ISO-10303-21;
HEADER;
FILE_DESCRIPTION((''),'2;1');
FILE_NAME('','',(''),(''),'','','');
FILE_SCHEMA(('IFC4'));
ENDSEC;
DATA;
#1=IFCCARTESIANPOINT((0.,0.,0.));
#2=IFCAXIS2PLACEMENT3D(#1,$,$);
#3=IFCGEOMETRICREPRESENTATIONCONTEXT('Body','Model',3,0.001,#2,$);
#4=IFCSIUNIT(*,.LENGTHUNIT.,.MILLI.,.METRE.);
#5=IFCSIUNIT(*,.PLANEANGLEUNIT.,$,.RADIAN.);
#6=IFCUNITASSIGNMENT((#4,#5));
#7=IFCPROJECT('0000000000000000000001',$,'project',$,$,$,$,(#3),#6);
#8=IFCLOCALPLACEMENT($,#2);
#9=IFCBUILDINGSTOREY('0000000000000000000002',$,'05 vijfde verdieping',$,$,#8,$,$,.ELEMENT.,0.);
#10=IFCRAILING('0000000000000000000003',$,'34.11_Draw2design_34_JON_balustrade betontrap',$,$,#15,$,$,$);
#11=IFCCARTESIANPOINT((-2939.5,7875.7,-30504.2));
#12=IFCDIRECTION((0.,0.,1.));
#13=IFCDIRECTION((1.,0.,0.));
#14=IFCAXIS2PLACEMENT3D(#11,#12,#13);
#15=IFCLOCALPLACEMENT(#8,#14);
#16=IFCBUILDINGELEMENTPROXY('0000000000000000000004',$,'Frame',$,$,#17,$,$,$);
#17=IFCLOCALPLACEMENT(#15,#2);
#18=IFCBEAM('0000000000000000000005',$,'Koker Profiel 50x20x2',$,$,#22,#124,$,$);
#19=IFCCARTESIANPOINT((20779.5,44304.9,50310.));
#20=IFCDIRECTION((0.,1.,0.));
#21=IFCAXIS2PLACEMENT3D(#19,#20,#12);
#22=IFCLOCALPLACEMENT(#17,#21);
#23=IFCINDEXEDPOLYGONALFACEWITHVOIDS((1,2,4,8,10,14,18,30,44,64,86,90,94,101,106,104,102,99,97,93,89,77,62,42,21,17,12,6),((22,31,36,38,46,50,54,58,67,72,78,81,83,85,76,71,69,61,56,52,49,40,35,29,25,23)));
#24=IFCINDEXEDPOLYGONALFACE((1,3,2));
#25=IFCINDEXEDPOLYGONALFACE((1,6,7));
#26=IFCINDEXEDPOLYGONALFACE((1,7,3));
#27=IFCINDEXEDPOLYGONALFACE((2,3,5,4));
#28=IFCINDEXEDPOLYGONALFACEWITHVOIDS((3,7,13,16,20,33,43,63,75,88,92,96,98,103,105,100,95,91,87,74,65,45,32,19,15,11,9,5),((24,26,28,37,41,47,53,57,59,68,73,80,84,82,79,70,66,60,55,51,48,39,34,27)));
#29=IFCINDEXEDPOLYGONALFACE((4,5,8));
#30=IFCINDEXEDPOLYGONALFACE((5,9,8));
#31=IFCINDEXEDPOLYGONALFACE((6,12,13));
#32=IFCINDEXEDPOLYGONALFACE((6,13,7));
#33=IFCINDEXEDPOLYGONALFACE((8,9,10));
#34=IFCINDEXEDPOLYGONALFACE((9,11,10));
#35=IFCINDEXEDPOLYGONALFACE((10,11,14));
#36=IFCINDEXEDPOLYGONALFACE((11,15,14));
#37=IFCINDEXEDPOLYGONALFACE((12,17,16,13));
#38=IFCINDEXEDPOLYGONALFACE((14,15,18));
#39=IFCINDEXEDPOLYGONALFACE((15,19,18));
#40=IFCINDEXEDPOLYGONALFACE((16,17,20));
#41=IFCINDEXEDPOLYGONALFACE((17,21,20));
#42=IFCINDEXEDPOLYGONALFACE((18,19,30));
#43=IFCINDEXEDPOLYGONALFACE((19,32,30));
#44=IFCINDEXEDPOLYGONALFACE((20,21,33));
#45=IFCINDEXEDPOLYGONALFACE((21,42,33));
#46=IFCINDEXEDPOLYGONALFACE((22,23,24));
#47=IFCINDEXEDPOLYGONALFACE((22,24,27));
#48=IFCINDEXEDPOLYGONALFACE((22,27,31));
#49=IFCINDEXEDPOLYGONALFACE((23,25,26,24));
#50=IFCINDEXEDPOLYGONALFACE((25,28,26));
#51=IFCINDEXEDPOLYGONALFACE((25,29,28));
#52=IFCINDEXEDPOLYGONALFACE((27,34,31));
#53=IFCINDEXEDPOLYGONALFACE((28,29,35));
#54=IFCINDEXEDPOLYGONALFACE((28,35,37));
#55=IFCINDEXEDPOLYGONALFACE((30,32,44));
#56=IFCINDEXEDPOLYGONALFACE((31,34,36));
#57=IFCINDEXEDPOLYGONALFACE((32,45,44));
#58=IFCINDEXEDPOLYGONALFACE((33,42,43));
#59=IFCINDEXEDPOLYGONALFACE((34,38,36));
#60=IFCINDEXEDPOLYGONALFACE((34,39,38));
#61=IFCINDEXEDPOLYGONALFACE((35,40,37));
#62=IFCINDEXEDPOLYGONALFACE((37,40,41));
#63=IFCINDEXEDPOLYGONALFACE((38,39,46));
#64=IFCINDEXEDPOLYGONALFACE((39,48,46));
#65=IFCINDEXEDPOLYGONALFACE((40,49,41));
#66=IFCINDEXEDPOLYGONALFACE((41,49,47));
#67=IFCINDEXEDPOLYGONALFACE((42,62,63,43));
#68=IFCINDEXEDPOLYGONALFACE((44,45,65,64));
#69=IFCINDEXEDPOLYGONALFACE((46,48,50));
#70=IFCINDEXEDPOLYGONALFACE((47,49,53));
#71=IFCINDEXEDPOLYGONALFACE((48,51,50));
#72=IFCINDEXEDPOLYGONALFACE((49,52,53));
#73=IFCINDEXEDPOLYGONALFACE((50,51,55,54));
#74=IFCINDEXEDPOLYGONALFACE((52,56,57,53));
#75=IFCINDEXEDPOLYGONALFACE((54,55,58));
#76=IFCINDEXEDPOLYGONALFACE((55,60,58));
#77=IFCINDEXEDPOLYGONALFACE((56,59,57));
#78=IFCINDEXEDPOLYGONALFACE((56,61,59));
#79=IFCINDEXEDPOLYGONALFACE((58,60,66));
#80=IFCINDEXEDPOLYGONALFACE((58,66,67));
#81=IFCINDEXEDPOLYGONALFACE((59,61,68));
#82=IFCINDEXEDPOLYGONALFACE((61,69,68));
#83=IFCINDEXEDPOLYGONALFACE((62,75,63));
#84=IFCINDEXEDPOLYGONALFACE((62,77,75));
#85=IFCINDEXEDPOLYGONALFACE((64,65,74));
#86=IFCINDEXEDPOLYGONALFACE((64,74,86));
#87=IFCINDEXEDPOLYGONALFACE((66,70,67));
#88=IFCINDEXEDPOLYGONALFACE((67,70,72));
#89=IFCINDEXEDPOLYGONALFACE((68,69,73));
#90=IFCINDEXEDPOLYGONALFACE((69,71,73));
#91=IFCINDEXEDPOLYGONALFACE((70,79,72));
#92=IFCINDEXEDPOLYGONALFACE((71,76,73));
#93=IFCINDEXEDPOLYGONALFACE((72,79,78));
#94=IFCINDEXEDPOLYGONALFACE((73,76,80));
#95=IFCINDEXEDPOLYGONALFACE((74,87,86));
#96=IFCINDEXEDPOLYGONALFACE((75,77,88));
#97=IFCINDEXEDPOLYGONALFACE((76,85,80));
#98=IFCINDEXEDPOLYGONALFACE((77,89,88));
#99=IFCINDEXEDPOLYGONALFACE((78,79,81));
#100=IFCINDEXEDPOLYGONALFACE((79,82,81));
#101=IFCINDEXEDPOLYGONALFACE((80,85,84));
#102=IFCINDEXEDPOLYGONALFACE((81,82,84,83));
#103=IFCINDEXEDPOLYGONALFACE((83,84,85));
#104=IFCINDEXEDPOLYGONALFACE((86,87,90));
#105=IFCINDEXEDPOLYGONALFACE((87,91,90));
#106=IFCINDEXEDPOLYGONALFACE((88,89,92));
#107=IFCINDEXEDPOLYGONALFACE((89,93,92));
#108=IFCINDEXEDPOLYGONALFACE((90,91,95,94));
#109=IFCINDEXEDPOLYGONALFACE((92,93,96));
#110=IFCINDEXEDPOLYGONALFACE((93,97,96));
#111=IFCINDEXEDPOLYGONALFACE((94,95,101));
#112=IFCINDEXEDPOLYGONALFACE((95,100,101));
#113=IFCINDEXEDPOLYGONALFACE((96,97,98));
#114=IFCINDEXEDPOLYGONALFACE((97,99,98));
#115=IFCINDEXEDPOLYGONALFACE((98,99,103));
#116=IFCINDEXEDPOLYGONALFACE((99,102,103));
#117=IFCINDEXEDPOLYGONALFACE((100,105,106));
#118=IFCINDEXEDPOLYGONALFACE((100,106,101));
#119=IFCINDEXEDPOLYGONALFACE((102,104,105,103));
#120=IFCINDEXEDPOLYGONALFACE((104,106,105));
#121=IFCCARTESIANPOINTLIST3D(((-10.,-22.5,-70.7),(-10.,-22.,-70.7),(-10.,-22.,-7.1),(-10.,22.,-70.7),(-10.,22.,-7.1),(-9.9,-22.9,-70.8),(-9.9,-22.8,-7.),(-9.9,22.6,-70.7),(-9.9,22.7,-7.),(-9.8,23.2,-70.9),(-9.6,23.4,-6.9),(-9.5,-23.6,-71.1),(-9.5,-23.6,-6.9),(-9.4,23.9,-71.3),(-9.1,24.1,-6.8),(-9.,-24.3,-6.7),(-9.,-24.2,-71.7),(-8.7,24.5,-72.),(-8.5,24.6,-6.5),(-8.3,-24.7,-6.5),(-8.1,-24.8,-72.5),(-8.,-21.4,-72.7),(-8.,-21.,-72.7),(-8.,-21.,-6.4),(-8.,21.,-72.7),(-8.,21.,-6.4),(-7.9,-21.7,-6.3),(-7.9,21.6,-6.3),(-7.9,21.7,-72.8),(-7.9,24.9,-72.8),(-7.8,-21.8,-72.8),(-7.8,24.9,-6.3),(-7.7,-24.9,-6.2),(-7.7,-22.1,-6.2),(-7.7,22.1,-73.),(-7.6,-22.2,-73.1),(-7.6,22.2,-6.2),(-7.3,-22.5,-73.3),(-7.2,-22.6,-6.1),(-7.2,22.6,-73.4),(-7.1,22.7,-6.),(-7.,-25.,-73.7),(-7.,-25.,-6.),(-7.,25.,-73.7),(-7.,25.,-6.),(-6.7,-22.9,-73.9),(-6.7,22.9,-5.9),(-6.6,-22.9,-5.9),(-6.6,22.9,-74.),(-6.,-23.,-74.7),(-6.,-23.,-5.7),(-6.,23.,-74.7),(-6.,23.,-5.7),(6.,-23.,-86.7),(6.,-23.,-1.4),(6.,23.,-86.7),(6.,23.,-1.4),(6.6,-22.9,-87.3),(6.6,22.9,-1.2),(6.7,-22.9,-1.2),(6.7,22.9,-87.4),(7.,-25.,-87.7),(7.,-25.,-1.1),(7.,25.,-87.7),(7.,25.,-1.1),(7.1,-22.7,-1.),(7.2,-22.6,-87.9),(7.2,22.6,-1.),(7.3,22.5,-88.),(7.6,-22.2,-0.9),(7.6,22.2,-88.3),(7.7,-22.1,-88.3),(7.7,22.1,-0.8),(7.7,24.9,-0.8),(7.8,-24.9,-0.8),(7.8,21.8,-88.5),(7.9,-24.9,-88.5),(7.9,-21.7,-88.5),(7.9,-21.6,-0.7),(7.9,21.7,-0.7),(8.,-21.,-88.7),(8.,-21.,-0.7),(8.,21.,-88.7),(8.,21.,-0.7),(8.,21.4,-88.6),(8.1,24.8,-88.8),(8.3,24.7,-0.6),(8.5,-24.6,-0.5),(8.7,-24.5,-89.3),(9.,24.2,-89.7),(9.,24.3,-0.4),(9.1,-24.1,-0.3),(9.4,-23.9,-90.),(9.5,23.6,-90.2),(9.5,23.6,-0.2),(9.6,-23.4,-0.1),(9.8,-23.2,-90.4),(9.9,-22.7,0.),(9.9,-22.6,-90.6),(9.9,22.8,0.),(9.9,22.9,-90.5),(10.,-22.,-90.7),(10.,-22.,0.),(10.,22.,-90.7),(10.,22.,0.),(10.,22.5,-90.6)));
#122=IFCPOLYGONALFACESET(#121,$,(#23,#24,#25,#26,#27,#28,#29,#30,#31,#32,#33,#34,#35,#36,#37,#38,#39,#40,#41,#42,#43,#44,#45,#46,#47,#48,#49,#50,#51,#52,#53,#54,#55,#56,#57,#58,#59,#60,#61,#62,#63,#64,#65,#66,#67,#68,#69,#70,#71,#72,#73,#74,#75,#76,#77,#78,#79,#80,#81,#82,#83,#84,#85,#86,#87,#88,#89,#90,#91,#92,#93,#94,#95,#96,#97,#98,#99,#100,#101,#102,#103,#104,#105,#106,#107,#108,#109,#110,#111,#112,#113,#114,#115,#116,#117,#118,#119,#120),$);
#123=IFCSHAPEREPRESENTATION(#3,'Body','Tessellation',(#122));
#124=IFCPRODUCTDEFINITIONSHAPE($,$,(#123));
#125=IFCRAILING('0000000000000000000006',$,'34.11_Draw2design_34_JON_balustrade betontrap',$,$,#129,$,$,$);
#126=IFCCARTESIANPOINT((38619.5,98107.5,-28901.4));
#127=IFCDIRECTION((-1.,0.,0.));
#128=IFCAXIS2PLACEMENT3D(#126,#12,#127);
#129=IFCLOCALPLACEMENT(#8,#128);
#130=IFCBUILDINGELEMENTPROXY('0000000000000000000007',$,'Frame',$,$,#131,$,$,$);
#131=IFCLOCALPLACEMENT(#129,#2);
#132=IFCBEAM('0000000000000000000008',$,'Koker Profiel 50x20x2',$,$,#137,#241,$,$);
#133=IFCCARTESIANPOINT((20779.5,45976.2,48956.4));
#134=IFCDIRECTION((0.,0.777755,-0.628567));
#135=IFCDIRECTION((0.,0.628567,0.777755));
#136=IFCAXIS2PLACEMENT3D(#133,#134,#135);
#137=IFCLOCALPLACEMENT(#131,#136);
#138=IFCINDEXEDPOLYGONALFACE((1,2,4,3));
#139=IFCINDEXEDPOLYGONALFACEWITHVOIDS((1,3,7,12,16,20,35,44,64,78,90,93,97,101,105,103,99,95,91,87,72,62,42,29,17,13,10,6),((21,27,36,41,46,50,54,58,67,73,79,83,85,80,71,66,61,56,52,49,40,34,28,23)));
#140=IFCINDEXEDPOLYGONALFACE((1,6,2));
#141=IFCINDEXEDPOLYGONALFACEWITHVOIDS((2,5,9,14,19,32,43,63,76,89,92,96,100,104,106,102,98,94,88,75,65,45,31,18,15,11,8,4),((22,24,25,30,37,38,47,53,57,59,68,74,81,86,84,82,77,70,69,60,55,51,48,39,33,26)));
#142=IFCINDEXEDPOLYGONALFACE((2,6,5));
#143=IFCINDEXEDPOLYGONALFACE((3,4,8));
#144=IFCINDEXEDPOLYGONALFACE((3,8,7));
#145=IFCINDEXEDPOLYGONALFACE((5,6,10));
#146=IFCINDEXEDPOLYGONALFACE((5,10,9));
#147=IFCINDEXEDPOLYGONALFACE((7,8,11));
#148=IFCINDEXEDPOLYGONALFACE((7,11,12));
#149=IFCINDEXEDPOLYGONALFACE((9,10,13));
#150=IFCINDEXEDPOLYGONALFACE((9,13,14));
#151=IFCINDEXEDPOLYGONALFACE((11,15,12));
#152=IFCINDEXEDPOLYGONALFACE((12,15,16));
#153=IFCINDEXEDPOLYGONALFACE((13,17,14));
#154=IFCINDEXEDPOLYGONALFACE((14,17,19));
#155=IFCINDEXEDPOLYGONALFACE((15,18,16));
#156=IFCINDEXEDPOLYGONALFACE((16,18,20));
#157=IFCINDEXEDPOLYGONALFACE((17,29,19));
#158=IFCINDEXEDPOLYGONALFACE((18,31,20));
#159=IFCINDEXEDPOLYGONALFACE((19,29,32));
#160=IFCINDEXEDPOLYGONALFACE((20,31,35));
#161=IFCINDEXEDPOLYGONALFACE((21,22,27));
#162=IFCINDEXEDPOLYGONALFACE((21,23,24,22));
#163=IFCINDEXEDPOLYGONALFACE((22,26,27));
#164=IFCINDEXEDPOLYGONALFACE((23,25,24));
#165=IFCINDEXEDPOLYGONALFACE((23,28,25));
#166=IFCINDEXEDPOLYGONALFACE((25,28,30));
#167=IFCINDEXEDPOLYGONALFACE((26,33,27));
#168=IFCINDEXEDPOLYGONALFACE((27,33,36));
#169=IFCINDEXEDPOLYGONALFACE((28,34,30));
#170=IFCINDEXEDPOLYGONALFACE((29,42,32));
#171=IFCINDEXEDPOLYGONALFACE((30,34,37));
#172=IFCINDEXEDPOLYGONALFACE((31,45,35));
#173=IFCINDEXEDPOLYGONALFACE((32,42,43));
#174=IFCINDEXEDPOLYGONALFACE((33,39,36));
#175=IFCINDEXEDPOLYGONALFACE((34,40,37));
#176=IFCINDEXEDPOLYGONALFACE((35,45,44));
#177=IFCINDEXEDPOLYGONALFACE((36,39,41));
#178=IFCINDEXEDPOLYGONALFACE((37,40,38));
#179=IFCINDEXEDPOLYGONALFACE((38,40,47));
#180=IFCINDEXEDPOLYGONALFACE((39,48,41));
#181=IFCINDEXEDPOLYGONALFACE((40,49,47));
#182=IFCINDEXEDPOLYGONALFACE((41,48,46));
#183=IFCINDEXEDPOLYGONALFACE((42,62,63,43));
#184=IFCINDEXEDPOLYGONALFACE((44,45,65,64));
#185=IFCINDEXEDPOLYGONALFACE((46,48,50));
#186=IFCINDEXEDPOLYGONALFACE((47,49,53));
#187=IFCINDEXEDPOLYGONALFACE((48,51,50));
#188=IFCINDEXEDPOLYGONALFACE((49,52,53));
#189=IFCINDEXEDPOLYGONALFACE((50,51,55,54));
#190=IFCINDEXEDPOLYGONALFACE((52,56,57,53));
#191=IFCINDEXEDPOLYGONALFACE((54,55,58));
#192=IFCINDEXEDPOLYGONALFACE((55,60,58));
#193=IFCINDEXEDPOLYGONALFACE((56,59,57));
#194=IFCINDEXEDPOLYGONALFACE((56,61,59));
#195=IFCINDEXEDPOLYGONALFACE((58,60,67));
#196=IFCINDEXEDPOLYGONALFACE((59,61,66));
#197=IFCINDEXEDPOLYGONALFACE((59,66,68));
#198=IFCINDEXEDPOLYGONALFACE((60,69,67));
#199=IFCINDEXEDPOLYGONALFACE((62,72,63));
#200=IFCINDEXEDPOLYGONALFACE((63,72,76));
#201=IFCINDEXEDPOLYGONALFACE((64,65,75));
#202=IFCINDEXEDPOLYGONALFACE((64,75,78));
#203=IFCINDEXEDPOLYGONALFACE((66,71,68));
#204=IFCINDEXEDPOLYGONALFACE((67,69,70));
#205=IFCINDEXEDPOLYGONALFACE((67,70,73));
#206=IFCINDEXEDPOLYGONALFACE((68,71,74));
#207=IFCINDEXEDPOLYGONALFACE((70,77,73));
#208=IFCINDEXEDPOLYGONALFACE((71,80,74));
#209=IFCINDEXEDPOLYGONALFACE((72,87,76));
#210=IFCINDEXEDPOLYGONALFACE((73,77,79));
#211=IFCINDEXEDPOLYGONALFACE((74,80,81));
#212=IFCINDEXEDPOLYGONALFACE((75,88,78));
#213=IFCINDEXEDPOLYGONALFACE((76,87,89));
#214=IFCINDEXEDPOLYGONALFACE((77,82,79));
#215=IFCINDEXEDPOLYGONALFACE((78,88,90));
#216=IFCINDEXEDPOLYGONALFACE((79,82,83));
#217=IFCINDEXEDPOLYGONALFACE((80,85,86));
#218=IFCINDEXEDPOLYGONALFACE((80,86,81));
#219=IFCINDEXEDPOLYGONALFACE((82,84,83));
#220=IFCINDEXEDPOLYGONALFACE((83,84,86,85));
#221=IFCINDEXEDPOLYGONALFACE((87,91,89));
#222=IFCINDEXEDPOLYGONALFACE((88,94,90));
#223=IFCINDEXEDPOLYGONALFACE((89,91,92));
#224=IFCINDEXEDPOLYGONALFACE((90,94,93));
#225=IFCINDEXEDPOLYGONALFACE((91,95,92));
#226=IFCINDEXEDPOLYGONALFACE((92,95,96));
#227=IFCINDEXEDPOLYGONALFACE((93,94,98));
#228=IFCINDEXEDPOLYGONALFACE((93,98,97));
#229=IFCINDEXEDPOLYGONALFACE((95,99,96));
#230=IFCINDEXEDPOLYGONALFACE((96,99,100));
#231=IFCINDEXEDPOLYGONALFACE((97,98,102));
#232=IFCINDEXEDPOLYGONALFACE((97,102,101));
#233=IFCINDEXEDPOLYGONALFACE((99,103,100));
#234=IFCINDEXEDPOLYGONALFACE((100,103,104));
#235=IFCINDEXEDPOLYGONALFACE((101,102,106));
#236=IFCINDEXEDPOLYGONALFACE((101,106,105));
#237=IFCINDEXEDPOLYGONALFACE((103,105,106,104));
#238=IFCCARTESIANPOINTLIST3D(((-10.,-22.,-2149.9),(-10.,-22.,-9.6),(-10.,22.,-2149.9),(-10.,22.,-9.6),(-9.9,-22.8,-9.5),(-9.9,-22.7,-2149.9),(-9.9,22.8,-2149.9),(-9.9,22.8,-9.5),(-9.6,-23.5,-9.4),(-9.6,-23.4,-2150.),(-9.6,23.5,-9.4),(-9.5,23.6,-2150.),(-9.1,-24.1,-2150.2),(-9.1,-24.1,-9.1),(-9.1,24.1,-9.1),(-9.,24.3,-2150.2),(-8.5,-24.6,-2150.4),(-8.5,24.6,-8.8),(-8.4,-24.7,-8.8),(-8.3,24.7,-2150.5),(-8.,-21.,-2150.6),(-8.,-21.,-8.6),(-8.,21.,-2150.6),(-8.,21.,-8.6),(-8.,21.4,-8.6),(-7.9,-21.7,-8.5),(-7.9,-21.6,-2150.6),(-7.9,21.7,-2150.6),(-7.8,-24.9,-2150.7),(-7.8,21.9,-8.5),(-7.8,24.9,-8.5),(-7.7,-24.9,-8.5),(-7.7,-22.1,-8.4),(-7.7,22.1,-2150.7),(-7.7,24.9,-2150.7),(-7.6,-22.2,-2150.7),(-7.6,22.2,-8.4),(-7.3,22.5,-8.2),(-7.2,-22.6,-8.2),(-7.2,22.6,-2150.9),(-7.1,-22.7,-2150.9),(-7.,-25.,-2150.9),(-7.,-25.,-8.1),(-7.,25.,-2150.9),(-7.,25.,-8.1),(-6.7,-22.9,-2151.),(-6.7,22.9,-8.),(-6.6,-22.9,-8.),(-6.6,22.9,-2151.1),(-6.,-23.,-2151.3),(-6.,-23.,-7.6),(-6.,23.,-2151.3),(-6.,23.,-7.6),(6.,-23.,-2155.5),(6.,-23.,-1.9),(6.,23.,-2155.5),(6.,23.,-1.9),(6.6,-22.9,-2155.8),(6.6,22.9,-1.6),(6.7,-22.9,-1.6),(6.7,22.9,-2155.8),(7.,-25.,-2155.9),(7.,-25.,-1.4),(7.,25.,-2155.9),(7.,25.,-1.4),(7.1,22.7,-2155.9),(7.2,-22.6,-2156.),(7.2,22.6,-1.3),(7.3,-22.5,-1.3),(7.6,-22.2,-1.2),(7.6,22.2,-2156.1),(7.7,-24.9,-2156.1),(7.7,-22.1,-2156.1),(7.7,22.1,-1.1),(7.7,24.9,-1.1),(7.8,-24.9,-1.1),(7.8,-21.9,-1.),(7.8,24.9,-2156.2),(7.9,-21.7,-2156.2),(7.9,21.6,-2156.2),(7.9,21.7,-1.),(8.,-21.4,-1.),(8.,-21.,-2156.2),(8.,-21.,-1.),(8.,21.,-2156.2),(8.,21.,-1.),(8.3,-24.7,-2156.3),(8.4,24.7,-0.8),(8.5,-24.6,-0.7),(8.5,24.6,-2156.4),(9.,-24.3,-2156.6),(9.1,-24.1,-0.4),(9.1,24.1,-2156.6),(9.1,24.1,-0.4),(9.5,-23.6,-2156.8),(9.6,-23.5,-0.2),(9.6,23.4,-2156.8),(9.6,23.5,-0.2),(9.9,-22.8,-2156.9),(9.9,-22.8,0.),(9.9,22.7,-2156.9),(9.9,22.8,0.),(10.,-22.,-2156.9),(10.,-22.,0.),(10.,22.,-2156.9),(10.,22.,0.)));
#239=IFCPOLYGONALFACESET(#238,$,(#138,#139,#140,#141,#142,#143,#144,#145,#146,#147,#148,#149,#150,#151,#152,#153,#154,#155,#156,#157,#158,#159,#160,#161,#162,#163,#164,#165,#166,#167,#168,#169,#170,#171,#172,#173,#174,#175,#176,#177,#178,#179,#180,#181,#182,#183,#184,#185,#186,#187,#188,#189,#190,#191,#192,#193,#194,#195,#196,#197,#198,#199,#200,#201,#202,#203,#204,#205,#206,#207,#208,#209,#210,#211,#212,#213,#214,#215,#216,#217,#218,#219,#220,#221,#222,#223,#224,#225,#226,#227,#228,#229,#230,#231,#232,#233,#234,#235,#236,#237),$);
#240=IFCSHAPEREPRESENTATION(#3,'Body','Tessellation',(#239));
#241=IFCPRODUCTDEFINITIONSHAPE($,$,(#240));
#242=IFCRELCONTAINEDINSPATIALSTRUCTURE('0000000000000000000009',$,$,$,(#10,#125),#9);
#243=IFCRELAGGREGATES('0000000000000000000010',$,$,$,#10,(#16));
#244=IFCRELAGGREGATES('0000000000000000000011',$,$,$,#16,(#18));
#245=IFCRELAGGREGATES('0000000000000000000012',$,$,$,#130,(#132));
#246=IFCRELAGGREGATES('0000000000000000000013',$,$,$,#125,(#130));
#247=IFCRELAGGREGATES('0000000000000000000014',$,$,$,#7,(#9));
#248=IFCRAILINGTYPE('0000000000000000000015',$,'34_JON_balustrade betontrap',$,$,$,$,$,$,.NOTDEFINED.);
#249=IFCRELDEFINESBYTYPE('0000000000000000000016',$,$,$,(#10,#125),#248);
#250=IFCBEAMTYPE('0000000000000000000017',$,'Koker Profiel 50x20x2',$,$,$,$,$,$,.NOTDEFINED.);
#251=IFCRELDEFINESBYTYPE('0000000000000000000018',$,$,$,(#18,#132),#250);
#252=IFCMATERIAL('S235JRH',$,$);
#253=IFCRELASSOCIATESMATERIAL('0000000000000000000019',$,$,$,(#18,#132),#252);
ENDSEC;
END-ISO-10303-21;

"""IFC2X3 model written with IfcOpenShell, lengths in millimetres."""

from ifc_helpers import new_model, si_unit, frame, origin, origin_2d, place, context, project, spatial, hollow_rectangle, extrude, clip, halfspace, source, transform, mapped, material, type_object, element, aggregate, save


model = new_model("IFC2X3")

# Units and contexts
model_context = context("Model", 3, precision=0.001, world=origin(), identifier="Body")
ifc_project = project(units=[si_unit("LENGTHUNIT", "METRE", prefix="MILLI"), si_unit("PLANEANGLEUNIT", "RADIAN")], contexts=[model_context])

# Storey
storey_placement = place(None, origin())
storey = spatial("IfcBuildingStorey", under=ifc_project, at=storey_placement, Name="05 vijfde verdieping", CompositionType="ELEMENT", Elevation=0.0)

# Railing, building element proxy, beam
railing_type_1 = type_object("IfcRailingType", Name="34_JON_balustrade betontrap")
railing_1_placement = place(storey_placement, frame((-2939.5, 7875.7, -30504.2), z_axis=(0.0, 0.0, 1.0), x_axis=(1.0, 0.0, 0.0)))
railing_1 = element("IfcRailing", 1, at=railing_1_placement, inside=storey, type_object=railing_type_1, Name="34.11_Draw2design_34_JON_balustrade betontrap")
ifc_material_1 = material(Name="S235JRH")
proxy_1_placement = place(railing_1_placement, origin())
proxy_1 = element("IfcBuildingElementProxy", 2, at=proxy_1_placement, Name="Frame")
aggregate(railing_1, [proxy_1])
beam_type_1 = type_object("IfcBeamType", Name="Koker Profiel 50x20x2")
shared_shape_1 = source(origin(), model_context, "Body", "Clipping", [
    clip(clip(extrude(hollow_rectangle(XDim=20.0, YDim=50.0, WallThickness=2.0, InnerFilletRadius=2.0, OuterFilletRadius=3.0, at=origin_2d()), origin(), (0.0, 0.0, -1.0), 90.7), halfspace(frame((-10.0, 25.0, -7.1), z_axis=(-0.33335, 0.0, 0.942803), x_axis=(0.0, 1.0, 0.0)), False)), halfspace(frame((-10.0, -25.0, -70.7), z_axis=(-0.707107, 0.0, -0.707107), x_axis=(0.0, -1.0, 0.0)), False)),
])
beam_1_placement = place(proxy_1_placement, frame((20779.5, 44304.9, 50310.0), z_axis=(0.0, 1.0, 0.0), x_axis=(0.0, 0.0, 1.0)))
beam_1 = element("IfcBeam", 3, at=beam_1_placement, type_object=beam_type_1, material=ifc_material_1, Name="Koker Profiel 50x20x2", context=model_context, shape_type="MappedRepresentation", body=[
    mapped(shared_shape_1, transform((0.0, 0.0, 0.0), scale=1.0)),
])

# Railing, building element proxy, beam
railing_2_placement = place(storey_placement, frame((38619.5, 98107.5, -28901.4), z_axis=(0.0, 0.0, 1.0), x_axis=(-1.0, 0.0, 0.0)))
railing_2 = element("IfcRailing", 4, at=railing_2_placement, inside=storey, type_object=railing_type_1, Name="34.11_Draw2design_34_JON_balustrade betontrap")
proxy_2_placement = place(railing_2_placement, origin())
proxy_2 = element("IfcBuildingElementProxy", 5, at=proxy_2_placement, Name="Frame")
shared_shape_2 = source(origin(), model_context, "Body", "Clipping", [
    clip(clip(extrude(hollow_rectangle(XDim=20.0, YDim=50.0, WallThickness=2.0, InnerFilletRadius=2.0, OuterFilletRadius=3.0, at=origin_2d()), origin(), (0.0, 0.0, -1.0), 2156.9), halfspace(frame((-10.0, 25.0, -9.6), z_axis=(-0.430948, 0.0, 0.902377), x_axis=(-0.902377, 0.0, -0.430948)), False)), halfspace(frame((-10.0, -25.0, -2149.9), z_axis=(-0.33335, 0.0, -0.942803), x_axis=(0.0, -1.0, 0.0)), False)),
])
beam_2_placement = place(proxy_2_placement, frame((20779.5, 45976.2, 48956.4), z_axis=(0.0, 0.777755, -0.628567), x_axis=(0.0, 0.628567, 0.777755)))
beam_2 = element("IfcBeam", 6, at=beam_2_placement, type_object=beam_type_1, material=ifc_material_1, Name="Koker Profiel 50x20x2", context=model_context, shape_type="MappedRepresentation", body=[
    mapped(shared_shape_2, transform((0.0, 0.0, 0.0), scale=1.0)),
])

aggregate(proxy_1, [beam_1])
aggregate(proxy_2, [beam_2])

aggregate(railing_2, [proxy_2])

save(model, "model.ifc")
